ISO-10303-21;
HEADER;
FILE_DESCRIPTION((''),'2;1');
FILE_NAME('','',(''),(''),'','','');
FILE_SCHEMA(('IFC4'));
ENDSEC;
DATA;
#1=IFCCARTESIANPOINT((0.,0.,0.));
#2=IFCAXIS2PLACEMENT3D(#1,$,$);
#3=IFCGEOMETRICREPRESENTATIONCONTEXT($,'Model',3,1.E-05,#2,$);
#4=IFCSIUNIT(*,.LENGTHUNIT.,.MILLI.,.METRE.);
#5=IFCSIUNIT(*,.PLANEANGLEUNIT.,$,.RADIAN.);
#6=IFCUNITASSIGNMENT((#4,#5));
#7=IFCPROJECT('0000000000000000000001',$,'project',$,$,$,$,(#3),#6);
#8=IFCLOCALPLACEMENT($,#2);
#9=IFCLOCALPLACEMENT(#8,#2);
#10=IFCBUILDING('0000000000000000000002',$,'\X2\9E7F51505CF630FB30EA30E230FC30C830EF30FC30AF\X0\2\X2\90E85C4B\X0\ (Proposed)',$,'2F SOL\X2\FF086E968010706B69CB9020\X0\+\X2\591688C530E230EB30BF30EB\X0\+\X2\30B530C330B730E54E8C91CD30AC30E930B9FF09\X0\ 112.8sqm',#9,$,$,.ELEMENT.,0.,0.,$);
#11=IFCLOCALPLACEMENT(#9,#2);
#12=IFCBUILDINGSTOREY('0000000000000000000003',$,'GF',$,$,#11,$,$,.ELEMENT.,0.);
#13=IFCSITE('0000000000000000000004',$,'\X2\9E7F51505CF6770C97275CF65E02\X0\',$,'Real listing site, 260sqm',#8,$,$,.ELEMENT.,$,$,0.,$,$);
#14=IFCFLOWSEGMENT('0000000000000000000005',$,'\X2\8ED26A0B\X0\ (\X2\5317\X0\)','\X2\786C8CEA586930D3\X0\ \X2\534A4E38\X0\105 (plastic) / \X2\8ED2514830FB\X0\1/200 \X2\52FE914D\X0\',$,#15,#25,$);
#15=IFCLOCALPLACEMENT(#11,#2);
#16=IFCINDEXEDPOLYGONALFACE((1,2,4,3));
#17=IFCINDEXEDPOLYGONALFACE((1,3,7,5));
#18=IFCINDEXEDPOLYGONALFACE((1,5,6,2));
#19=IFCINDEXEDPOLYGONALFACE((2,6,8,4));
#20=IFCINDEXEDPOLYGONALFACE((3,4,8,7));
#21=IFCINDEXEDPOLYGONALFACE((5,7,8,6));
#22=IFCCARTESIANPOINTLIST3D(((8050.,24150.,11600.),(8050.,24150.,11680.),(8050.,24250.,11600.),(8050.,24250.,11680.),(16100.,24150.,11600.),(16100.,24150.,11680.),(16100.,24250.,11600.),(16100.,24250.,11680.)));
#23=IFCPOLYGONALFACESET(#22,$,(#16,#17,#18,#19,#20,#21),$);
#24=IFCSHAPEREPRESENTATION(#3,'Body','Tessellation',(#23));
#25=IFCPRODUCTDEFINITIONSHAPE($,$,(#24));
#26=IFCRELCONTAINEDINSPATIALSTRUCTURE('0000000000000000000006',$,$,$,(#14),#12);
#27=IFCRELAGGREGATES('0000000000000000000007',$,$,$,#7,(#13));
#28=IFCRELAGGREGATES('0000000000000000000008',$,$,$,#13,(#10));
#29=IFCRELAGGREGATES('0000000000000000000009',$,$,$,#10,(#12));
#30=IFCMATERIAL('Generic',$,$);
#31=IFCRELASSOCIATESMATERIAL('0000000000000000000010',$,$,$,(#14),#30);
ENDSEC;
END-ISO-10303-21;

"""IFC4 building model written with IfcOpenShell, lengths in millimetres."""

from ifc_helpers import new_model, si_unit, frame, frame_2d, origin, place, context, project, spatial, rectangle, extrude, material, element, save


model = new_model("IFC4")

# Units and contexts
model_context = context("Model", 3, precision=1e-05, world=origin())
ifc_project = project(units=[si_unit("LENGTHUNIT", "METRE", prefix="MILLI"), si_unit("PLANEANGLEUNIT", "RADIAN")], contexts=[model_context])

# Site, building, storey
site_placement = place(None, origin())
site = spatial("IfcSite", under=ifc_project, at=site_placement, Name="鹿児島県霧島市", ObjectType="Real listing site, 260sqm", CompositionType="ELEMENT", RefElevation=0.0)
building_placement = place(site_placement, origin())
building = spatial("IfcBuilding", under=site, at=building_placement, Name="鹿児島・リモートワーク2部屋 (Proposed)", ObjectType="2F SOL（準耐火構造+外装モルタル+サッシュ二重ガラス） 112.8sqm", CompositionType="ELEMENT", ElevationOfRefHeight=0.0, ElevationOfTerrain=0.0)
storey_placement = place(building_placement, origin())
storey = spatial("IfcBuildingStorey", under=building, at=storey_placement, Name="GF", CompositionType="ELEMENT", Elevation=0.0)

# Shared definitions
ifc_material_1 = material(Name="Generic")

# Flow segment
flow_segment_placement = place(storey_placement, frame((4025.0, 12075.0, 5800.0)))
element("IfcFlowSegment", 1, at=flow_segment_placement, inside=storey, material=ifc_material_1, Name="軒樋 (北)", Description="硬質塩ビ 半丸105 (plastic) / 軒先・1/200 勾配", context=model_context, shape_type="SweptSolid", body=[
    extrude(rectangle(XDim=8050.0, YDim=100.0, at=frame_2d((4025.0, 50.0))), frame((4025.0, 12075.0, 5800.0)), (0.0, 0.0, 1.0), 80.0),
])

save(model, "model.ifc")
